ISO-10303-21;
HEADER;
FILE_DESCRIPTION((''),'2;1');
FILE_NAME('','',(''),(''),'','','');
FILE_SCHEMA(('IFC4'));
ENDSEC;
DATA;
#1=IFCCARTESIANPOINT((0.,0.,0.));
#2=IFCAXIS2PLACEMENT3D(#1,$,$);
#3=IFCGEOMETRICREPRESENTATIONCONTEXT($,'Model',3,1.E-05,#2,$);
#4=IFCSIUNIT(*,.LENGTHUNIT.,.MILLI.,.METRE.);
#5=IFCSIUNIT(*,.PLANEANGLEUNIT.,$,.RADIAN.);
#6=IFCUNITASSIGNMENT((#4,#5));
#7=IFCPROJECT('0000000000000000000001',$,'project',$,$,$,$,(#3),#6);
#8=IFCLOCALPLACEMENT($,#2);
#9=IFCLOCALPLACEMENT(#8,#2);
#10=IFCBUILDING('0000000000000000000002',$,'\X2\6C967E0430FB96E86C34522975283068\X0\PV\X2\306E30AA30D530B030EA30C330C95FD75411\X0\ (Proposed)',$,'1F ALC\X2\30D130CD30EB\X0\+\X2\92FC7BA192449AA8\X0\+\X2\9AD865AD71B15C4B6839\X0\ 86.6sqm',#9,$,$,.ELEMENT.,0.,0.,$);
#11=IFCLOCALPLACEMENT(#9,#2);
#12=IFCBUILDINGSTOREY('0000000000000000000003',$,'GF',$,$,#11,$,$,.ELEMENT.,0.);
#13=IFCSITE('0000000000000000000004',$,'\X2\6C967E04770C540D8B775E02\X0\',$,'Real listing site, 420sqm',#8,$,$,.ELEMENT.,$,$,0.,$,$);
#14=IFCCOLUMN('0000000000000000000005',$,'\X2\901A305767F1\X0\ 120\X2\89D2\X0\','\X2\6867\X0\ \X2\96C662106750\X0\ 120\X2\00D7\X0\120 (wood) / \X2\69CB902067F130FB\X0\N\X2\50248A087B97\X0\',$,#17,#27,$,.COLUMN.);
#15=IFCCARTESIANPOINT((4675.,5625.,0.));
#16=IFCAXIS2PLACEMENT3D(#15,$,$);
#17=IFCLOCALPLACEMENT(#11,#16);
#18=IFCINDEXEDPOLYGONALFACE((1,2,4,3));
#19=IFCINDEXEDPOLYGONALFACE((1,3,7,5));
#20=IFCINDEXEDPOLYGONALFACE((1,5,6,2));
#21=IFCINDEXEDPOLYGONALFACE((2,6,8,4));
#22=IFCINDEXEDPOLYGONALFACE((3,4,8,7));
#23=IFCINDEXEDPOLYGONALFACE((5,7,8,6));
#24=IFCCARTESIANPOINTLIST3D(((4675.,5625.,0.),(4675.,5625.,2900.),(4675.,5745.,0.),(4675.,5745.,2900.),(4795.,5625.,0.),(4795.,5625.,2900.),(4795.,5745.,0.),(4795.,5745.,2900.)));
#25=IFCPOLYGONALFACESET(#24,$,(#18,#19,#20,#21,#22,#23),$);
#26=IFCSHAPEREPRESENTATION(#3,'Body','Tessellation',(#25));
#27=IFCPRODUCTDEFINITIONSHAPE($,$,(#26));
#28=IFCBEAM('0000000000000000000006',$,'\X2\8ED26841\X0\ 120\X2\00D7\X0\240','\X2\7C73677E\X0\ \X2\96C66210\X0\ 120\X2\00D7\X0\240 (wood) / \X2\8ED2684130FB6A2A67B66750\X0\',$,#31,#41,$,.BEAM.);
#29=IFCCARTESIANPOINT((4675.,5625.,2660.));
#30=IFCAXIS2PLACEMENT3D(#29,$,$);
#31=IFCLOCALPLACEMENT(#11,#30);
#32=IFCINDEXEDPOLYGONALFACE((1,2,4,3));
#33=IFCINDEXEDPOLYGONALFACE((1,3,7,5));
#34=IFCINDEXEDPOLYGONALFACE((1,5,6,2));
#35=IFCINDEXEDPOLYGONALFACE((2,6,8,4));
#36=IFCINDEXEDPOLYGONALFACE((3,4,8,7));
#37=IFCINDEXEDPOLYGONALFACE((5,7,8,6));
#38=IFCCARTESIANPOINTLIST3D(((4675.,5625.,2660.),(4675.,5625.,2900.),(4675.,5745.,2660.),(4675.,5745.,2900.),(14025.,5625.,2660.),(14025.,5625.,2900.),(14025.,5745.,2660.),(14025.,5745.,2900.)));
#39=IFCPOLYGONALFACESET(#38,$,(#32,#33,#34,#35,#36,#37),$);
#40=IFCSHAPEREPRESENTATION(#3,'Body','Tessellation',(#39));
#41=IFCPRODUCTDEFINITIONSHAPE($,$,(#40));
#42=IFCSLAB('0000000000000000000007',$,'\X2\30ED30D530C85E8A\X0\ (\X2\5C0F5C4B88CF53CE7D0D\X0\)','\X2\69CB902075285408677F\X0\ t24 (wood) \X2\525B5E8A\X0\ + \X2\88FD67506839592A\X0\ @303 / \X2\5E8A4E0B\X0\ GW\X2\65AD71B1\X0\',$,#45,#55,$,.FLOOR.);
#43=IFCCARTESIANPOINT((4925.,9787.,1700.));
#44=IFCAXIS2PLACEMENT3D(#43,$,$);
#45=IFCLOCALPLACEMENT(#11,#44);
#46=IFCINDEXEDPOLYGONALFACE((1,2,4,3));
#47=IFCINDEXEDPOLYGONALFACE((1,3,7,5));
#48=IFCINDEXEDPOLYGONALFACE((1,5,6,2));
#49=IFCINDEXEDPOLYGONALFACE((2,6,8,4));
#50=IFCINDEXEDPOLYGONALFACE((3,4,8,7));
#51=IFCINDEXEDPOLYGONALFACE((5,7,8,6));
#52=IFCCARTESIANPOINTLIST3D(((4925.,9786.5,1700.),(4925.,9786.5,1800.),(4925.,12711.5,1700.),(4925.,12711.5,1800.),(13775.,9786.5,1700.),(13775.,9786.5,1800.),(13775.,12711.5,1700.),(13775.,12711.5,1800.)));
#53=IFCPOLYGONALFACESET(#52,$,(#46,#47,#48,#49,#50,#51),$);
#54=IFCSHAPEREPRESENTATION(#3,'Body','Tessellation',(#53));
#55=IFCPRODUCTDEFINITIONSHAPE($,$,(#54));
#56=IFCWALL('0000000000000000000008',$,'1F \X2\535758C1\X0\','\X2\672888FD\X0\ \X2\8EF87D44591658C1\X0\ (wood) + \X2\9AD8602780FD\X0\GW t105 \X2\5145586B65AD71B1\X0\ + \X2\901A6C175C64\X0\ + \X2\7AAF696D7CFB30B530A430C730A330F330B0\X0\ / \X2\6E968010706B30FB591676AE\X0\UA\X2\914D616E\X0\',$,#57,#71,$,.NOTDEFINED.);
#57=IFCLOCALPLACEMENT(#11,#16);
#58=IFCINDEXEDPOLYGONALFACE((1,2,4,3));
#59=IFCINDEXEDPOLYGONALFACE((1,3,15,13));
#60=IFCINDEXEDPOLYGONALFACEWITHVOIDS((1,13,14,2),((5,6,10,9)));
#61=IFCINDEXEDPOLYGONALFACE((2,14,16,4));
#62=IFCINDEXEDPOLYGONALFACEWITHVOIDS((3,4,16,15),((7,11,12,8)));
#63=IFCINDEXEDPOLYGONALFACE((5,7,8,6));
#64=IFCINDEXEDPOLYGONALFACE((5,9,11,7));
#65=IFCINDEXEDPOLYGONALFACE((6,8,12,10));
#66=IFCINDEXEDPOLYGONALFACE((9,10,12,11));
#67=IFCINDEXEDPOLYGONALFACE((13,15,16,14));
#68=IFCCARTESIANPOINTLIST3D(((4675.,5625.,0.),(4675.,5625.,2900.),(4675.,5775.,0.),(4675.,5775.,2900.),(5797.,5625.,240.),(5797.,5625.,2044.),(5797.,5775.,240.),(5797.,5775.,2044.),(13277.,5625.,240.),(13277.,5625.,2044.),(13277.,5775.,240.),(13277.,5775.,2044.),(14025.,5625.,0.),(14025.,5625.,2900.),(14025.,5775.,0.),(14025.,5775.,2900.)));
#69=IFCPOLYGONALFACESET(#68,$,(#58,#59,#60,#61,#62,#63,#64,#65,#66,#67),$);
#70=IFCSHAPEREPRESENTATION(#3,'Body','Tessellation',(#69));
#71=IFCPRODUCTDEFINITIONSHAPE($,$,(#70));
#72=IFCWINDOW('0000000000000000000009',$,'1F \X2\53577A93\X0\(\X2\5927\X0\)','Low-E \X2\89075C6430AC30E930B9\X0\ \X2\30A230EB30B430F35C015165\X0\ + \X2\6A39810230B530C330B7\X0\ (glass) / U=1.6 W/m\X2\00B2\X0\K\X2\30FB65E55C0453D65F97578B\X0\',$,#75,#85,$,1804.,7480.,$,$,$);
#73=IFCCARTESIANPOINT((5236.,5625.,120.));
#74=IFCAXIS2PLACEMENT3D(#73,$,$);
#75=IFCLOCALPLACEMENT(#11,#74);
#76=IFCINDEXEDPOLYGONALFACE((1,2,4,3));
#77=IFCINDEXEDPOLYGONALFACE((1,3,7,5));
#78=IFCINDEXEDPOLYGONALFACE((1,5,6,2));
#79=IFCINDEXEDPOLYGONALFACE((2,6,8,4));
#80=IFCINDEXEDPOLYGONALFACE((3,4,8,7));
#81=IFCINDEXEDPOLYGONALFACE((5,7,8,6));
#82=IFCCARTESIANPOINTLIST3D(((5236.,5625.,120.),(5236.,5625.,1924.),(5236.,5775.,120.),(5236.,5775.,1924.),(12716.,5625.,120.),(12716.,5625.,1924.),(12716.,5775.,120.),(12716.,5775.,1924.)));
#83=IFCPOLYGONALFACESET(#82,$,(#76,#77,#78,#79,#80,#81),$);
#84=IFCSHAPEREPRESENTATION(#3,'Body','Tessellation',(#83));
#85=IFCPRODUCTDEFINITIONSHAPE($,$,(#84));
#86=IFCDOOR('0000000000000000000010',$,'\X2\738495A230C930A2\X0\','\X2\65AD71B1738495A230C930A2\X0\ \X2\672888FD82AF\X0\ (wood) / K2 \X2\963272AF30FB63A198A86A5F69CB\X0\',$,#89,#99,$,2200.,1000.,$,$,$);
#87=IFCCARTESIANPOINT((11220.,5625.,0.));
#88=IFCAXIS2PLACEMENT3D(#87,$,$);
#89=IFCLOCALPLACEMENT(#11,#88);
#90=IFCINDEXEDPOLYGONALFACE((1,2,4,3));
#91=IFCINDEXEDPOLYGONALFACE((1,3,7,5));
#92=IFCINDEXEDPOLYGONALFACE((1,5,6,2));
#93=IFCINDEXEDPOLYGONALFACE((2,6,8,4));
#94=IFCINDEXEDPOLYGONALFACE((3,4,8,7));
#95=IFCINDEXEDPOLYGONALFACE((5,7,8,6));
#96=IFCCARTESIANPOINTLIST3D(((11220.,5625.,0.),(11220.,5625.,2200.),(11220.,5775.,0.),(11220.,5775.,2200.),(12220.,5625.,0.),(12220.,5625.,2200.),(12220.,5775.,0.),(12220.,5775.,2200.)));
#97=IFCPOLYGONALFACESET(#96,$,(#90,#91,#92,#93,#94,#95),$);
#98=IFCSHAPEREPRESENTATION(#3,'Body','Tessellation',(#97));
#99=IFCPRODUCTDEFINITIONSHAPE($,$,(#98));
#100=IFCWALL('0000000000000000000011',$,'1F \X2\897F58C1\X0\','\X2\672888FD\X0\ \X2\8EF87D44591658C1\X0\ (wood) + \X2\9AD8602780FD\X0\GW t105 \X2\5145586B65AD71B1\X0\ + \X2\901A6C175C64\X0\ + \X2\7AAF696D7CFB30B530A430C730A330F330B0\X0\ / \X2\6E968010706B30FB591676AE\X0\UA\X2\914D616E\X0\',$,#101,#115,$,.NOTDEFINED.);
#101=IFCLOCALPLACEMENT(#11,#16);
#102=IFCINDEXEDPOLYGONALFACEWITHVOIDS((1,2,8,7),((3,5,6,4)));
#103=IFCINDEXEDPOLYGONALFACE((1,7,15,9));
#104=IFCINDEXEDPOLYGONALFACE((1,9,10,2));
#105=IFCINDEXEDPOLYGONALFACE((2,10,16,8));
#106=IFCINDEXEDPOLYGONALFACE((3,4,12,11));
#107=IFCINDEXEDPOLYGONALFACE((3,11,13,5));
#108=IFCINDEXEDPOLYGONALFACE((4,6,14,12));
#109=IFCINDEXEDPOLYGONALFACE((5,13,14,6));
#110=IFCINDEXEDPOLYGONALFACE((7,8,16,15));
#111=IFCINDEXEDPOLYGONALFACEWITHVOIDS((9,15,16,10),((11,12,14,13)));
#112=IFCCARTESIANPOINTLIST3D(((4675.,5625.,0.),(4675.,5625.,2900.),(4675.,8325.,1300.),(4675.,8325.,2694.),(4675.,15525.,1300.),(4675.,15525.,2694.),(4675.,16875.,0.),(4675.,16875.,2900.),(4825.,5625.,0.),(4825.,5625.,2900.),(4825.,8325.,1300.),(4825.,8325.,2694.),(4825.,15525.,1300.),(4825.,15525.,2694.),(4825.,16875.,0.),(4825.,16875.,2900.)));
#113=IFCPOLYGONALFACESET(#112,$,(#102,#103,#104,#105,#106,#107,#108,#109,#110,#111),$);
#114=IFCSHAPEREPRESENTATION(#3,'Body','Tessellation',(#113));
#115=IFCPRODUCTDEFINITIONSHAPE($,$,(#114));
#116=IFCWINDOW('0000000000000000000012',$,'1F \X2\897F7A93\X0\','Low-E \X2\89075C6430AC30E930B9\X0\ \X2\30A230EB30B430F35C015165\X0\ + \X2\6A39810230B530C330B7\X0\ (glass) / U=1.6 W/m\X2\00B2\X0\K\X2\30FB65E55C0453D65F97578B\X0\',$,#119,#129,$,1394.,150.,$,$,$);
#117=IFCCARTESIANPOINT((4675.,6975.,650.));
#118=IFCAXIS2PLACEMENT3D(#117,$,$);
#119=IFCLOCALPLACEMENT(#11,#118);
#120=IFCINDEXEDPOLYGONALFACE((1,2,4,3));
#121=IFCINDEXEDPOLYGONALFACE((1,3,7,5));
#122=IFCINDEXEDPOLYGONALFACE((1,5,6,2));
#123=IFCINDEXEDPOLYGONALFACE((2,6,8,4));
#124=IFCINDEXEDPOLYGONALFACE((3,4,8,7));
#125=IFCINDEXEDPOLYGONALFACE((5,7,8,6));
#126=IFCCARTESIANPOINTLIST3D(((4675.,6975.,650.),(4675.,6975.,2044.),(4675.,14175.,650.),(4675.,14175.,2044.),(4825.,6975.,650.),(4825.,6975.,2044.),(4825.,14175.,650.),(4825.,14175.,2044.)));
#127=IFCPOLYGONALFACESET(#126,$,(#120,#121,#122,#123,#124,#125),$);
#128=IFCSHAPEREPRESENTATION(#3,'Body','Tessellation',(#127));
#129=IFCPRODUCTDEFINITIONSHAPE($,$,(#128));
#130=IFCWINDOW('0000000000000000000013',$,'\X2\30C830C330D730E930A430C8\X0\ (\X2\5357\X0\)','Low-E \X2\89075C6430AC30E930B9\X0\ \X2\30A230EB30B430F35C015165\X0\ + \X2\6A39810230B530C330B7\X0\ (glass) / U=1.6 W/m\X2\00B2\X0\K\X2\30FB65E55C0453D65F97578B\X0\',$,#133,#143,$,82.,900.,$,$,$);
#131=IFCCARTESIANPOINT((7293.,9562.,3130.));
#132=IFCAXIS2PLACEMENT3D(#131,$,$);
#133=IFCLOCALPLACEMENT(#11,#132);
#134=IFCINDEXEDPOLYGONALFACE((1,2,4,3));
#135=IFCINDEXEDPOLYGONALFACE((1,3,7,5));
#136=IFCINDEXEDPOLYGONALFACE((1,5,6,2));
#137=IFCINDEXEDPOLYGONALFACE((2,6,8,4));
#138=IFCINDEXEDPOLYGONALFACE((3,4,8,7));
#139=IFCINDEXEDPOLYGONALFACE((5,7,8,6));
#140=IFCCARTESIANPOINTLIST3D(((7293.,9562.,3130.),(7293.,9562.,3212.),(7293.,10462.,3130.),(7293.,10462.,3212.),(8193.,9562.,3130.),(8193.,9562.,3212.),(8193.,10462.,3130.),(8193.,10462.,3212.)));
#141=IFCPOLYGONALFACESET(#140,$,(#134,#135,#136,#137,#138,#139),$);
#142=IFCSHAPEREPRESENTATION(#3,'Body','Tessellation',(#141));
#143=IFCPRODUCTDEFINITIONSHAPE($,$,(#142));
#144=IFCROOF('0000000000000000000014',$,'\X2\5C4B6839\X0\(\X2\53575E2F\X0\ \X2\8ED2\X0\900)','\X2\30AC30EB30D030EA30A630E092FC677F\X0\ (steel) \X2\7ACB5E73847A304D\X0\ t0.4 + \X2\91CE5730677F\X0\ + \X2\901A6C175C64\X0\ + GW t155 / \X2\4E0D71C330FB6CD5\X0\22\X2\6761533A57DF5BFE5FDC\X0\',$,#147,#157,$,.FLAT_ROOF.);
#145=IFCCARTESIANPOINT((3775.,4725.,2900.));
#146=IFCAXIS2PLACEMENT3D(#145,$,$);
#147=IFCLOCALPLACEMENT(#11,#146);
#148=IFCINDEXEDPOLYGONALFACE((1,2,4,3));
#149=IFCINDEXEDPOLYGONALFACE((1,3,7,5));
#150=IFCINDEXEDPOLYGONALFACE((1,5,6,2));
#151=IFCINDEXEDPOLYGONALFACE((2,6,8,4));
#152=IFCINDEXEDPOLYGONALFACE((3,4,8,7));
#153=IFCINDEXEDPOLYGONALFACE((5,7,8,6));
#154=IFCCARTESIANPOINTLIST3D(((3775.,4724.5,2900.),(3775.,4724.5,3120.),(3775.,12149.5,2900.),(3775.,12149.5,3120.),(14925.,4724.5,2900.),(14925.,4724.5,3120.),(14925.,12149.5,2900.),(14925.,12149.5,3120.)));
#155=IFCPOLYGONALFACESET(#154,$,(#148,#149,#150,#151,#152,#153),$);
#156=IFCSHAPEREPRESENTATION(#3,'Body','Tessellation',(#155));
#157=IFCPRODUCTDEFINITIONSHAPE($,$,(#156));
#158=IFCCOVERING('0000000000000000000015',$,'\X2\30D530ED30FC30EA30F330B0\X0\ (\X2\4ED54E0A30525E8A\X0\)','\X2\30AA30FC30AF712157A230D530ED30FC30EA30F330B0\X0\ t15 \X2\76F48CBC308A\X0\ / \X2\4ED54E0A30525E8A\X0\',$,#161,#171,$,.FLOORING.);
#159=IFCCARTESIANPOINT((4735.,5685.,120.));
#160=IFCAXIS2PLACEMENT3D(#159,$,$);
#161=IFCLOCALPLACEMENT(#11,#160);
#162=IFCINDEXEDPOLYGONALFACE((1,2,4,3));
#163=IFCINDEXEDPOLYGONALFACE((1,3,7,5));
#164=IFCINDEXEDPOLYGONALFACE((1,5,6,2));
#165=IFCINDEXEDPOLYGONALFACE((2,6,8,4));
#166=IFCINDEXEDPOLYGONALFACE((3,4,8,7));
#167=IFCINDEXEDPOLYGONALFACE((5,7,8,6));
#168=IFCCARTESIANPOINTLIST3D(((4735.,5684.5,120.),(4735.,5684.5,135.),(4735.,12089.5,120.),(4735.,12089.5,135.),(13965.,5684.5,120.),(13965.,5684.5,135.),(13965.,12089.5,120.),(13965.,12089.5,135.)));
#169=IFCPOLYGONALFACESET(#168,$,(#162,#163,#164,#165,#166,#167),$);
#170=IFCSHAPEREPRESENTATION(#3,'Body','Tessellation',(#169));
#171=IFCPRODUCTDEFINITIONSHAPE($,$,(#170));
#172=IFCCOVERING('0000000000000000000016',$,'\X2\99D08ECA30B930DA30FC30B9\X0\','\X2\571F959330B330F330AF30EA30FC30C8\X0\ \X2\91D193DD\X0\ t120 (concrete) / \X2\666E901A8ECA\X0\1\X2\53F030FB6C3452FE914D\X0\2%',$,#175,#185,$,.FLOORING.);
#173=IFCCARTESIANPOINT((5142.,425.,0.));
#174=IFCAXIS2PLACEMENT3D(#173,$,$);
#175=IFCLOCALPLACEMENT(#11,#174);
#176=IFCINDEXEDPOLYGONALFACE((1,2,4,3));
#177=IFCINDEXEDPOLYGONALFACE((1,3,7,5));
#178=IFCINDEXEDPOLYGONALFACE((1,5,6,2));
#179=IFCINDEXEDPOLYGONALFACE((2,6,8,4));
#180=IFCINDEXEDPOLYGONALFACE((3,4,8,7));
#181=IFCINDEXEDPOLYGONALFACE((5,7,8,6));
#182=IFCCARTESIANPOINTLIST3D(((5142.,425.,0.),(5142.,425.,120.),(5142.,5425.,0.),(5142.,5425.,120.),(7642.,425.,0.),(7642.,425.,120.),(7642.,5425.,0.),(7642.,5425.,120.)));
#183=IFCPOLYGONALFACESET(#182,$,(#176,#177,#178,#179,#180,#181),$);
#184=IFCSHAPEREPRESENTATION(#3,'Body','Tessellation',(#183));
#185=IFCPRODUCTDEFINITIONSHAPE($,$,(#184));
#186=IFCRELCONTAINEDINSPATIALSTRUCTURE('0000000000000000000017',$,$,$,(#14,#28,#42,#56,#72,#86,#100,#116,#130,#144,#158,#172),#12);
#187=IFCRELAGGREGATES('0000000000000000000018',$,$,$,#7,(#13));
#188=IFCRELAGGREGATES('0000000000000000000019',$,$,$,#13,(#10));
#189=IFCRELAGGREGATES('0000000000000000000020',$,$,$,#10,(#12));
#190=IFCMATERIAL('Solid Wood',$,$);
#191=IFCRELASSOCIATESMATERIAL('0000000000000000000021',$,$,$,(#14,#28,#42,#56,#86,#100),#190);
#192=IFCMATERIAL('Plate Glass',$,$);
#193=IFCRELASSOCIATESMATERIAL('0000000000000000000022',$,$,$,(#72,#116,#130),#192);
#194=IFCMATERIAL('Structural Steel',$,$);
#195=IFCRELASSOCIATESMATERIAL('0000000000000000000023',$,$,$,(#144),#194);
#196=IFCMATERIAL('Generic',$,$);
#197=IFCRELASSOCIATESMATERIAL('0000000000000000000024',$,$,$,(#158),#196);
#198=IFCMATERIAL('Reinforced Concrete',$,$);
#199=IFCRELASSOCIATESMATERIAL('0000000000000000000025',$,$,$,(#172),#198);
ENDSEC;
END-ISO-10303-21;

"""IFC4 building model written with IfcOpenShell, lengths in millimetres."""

from ifc_helpers import new_model, si_unit, frame, frame_2d, origin, place, context, project, spatial, rectangle, extrude, material, element, fill, save


model = new_model("IFC4")

# Units and contexts
model_context = context("Model", 3, precision=1e-05, world=origin())
ifc_project = project(units=[si_unit("LENGTHUNIT", "METRE", prefix="MILLI"), si_unit("PLANEANGLEUNIT", "RADIAN")], contexts=[model_context])

# Site, building, storey
site_placement = place(None, origin())
site = spatial("IfcSite", under=ifc_project, at=site_placement, Name="沖縄県名護市", ObjectType="Real listing site, 420sqm", CompositionType="ELEMENT", RefElevation=0.0)
building_placement = place(site_placement, origin())
building = spatial("IfcBuilding", under=site, at=building_placement, Name="沖縄・雨水利用とPVのオフグリッド志向 (Proposed)", ObjectType="1F ALCパネル+鋼管鉄骨+高断熱屋根 86.6sqm", CompositionType="ELEMENT", ElevationOfRefHeight=0.0, ElevationOfTerrain=0.0)
storey_placement = place(building_placement, origin())
storey = spatial("IfcBuildingStorey", under=building, at=storey_placement, Name="GF", CompositionType="ELEMENT", Elevation=0.0)

# Column
ifc_material_1 = material(Name="Solid Wood")
column_1_placement = place(storey_placement, frame((4675.0, 5625.0, 0.0)))
element("IfcColumn", 1, at=column_1_placement, inside=storey, material=ifc_material_1, Name="通し柱 120角", Description="桧 集成材 120×120 (wood) / 構造柱・N値計算", PredefinedType="COLUMN", context=model_context, shape_type="SweptSolid", body=[
    extrude(rectangle(XDim=120.0, YDim=120.0, at=frame_2d((60.0, 60.0))), frame((4675.0, 5625.0, 0.0)), (0.0, 0.0, 1.0), 2900.0),
])

# Beam
beam_1_placement = place(storey_placement, frame((4675.0, 5625.0, 2660.0)))
element("IfcBeam", 2, at=beam_1_placement, inside=storey, material=ifc_material_1, Name="軒桁 120×240", Description="米松 集成 120×240 (wood) / 軒桁・横架材", PredefinedType="BEAM", context=model_context, shape_type="SweptSolid", body=[
    extrude(rectangle(XDim=9350.0, YDim=120.0, at=frame_2d((4675.0, 60.0))), frame((4675.0, 5625.0, 2660.0)), (0.0, 0.0, 1.0), 240.0),
])

# Slab
ifc_material_2 = material(Name="Reinforced Concrete")
slab_1_placement = place(storey_placement, frame((4925.0, 9787.0, 1700.0)))
element("IfcSlab", 3, at=slab_1_placement, inside=storey, material=ifc_material_1, Name="ロフト床 (小屋裏収納)", Description="構造用合板 t24 (wood) 剛床 + 製材根太 @303 / 床下 GW断熱", PredefinedType="FLOOR", context=model_context, shape_type="SweptSolid", body=[
    extrude(rectangle(XDim=8850.0, YDim=2925.0, at=frame_2d((4425.0, 1462.0))), frame((4925.0, 9787.0, 1700.0)), (0.0, 0.0, 1.0), 100.0),
])

# Wall, openings, window, door
wall_1_placement = place(storey_placement, frame((4675.0, 5625.0, 0.0)))
wall_1 = element("IfcWall", 4, at=wall_1_placement, inside=storey, material=ifc_material_1, Name="1F 南壁", Description="木製 軸組外壁 (wood) + 高性能GW t105 充填断熱 + 通気層 + 窯業系サイディング / 準耐火・外皮UA配慮", PredefinedType="NOTDEFINED", context=model_context, shape_type="SweptSolid", body=[
    extrude(rectangle(XDim=9350.0, YDim=150.0, at=frame_2d((4675.0, 75.0))), frame((4675.0, 5625.0, 0.0)), (0.0, 0.0, 1.0), 2900.0),
])
opening_1_placement = place(storey_placement, frame((5236.0, 5625.0, 120.0)))
opening_1 = element("IfcOpeningElement", 5, at=opening_1_placement, cuts=wall_1, PredefinedType="NOTDEFINED", context=model_context, shape_type="SweptSolid", body=[
    extrude(rectangle(XDim=7480.0, YDim=150.0, at=frame_2d((3740.0, 75.0))), frame((5236.0, 5625.0, 120.0)), (0.0, 0.0, 1.0), 1804.0),
])
opening_2_placement = place(storey_placement, frame((11220.0, 5625.0, 0.0)))
opening_2 = element("IfcOpeningElement", 6, at=opening_2_placement, cuts=wall_1, PredefinedType="NOTDEFINED", context=model_context, shape_type="SweptSolid", body=[
    extrude(rectangle(XDim=1000.0, YDim=150.0, at=frame_2d((500.0, 75.0))), frame((11220.0, 5625.0, 0.0)), (0.0, 0.0, 1.0), 2200.0),
])
ifc_material_3 = material(Name="Plate Glass")
window_1_placement = place(storey_placement, frame((5236.0, 5625.0, 120.0)))
window_1 = element("IfcWindow", 7, at=window_1_placement, inside=storey, material=ifc_material_3, Name="1F 南窓(大)", Description="Low-E 複層ガラス アルゴン封入 + 樹脂サッシ (glass) / U=1.6 W/m²K・日射取得型", OverallHeight=1804.0, OverallWidth=7480.0, context=model_context, shape_type="SweptSolid", body=[
    extrude(rectangle(XDim=7480.0, YDim=150.0, at=frame_2d((3740.0, 75.0))), frame((5236.0, 5625.0, 120.0)), (0.0, 0.0, 1.0), 1804.0),
])
fill(opening_1, window_1)
door_placement = place(storey_placement, frame((11220.0, 5625.0, 0.0)))
door = element("IfcDoor", 8, at=door_placement, inside=storey, material=ifc_material_1, Name="玄関ドア", Description="断熱玄関ドア 木製芯 (wood) / K2 防犯・採風機構", OverallHeight=2200.0, OverallWidth=1000.0, context=model_context, shape_type="SweptSolid", body=[
    extrude(rectangle(XDim=1000.0, YDim=150.0, at=frame_2d((500.0, 75.0))), frame((11220.0, 5625.0, 0.0)), (0.0, 0.0, 1.0), 2200.0),
])
fill(opening_2, door)

# Wall, opening, window
wall_2_placement = place(storey_placement, frame((4675.0, 5625.0, 0.0)))
wall_2 = element("IfcWall", 9, at=wall_2_placement, inside=storey, material=ifc_material_1, Name="1F 西壁", Description="木製 軸組外壁 (wood) + 高性能GW t105 充填断熱 + 通気層 + 窯業系サイディング / 準耐火・外皮UA配慮", PredefinedType="NOTDEFINED", context=model_context, shape_type="SweptSolid", body=[
    extrude(rectangle(XDim=150.0, YDim=11250.0, at=frame_2d((75.0, 5625.0))), frame((4675.0, 5625.0, 0.0)), (0.0, 0.0, 1.0), 2900.0),
])
opening_3_placement = place(storey_placement, frame((4675.0, 6975.0, 650.0)))
opening_3 = element("IfcOpeningElement", 10, at=opening_3_placement, cuts=wall_2, PredefinedType="NOTDEFINED", context=model_context, shape_type="SweptSolid", body=[
    extrude(rectangle(XDim=150.0, YDim=7200.0, at=frame_2d((75.0, 3600.0))), frame((4675.0, 6975.0, 650.0)), (0.0, 0.0, 1.0), 1394.0),
])
window_2_placement = place(storey_placement, frame((4675.0, 6975.0, 650.0)))
window_2 = element("IfcWindow", 11, at=window_2_placement, inside=storey, material=ifc_material_3, Name="1F 西窓", Description="Low-E 複層ガラス アルゴン封入 + 樹脂サッシ (glass) / U=1.6 W/m²K・日射取得型", OverallHeight=1394.0, OverallWidth=150.0, context=model_context, shape_type="SweptSolid", body=[
    extrude(rectangle(XDim=150.0, YDim=7200.0, at=frame_2d((75.0, 3600.0))), frame((4675.0, 6975.0, 650.0)), (0.0, 0.0, 1.0), 1394.0),
])
fill(opening_3, window_2)

# Window
window_3_placement = place(storey_placement, frame((7293.0, 9562.0, 3130.0)))
element("IfcWindow", 12, at=window_3_placement, inside=storey, material=ifc_material_3, Name="トップライト (南)", Description="Low-E 複層ガラス アルゴン封入 + 樹脂サッシ (glass) / U=1.6 W/m²K・日射取得型", OverallHeight=82.0, OverallWidth=900.0, context=model_context, shape_type="SweptSolid", body=[
    extrude(rectangle(XDim=900.0, YDim=900.0, at=frame_2d((450.0, 450.0))), frame((7293.0, 9562.0, 3130.0)), (0.0, 0.0, 1.0), 82.0),
])

# Roof
ifc_material_4 = material(Name="Structural Steel")
roof_placement = place(storey_placement, frame((3775.0, 4725.0, 2900.0)))
element("IfcRoof", 13, at=roof_placement, inside=storey, material=ifc_material_4, Name="屋根(南帯 軒900)", Description="ガルバリウム鋼板 (steel) 立平葺き t0.4 + 野地板 + 通気層 + GW t155 / 不燃・法22条区域対応", PredefinedType="FLAT_ROOF", context=model_context, shape_type="SweptSolid", body=[
    extrude(rectangle(XDim=11150.0, YDim=7425.0, at=frame_2d((5575.0, 3712.0))), frame((3775.0, 4725.0, 2900.0)), (0.0, 0.0, 1.0), 220.0),
])

# Coverings
ifc_material_5 = material(Name="Generic")
covering_1_placement = place(storey_placement, frame((4735.0, 5685.0, 120.0)))
element("IfcCovering", 14, at=covering_1_placement, inside=storey, material=ifc_material_5, Name="フローリング (仕上げ床)", Description="オーク無垢フローリング t15 直貼り / 仕上げ床", PredefinedType="FLOORING", context=model_context, shape_type="SweptSolid", body=[
    extrude(rectangle(XDim=9230.0, YDim=6405.0, at=frame_2d((4615.0, 3202.0))), frame((4735.0, 5685.0, 120.0)), (0.0, 0.0, 1.0), 15.0),
])
covering_2_placement = place(storey_placement, frame((5142.0, 425.0, 0.0)))
element("IfcCovering", 15, at=covering_2_placement, inside=storey, material=ifc_material_2, Name="駐車スペース", Description="土間コンクリート 金鏝 t120 (concrete) / 普通車1台・水勾配2%", PredefinedType="FLOORING", context=model_context, shape_type="SweptSolid", body=[
    extrude(rectangle(XDim=2500.0, YDim=5000.0, at=frame_2d((1250.0, 2500.0))), frame((5142.0, 425.0, 0.0)), (0.0, 0.0, 1.0), 120.0),
])

save(model, "model.ifc")
